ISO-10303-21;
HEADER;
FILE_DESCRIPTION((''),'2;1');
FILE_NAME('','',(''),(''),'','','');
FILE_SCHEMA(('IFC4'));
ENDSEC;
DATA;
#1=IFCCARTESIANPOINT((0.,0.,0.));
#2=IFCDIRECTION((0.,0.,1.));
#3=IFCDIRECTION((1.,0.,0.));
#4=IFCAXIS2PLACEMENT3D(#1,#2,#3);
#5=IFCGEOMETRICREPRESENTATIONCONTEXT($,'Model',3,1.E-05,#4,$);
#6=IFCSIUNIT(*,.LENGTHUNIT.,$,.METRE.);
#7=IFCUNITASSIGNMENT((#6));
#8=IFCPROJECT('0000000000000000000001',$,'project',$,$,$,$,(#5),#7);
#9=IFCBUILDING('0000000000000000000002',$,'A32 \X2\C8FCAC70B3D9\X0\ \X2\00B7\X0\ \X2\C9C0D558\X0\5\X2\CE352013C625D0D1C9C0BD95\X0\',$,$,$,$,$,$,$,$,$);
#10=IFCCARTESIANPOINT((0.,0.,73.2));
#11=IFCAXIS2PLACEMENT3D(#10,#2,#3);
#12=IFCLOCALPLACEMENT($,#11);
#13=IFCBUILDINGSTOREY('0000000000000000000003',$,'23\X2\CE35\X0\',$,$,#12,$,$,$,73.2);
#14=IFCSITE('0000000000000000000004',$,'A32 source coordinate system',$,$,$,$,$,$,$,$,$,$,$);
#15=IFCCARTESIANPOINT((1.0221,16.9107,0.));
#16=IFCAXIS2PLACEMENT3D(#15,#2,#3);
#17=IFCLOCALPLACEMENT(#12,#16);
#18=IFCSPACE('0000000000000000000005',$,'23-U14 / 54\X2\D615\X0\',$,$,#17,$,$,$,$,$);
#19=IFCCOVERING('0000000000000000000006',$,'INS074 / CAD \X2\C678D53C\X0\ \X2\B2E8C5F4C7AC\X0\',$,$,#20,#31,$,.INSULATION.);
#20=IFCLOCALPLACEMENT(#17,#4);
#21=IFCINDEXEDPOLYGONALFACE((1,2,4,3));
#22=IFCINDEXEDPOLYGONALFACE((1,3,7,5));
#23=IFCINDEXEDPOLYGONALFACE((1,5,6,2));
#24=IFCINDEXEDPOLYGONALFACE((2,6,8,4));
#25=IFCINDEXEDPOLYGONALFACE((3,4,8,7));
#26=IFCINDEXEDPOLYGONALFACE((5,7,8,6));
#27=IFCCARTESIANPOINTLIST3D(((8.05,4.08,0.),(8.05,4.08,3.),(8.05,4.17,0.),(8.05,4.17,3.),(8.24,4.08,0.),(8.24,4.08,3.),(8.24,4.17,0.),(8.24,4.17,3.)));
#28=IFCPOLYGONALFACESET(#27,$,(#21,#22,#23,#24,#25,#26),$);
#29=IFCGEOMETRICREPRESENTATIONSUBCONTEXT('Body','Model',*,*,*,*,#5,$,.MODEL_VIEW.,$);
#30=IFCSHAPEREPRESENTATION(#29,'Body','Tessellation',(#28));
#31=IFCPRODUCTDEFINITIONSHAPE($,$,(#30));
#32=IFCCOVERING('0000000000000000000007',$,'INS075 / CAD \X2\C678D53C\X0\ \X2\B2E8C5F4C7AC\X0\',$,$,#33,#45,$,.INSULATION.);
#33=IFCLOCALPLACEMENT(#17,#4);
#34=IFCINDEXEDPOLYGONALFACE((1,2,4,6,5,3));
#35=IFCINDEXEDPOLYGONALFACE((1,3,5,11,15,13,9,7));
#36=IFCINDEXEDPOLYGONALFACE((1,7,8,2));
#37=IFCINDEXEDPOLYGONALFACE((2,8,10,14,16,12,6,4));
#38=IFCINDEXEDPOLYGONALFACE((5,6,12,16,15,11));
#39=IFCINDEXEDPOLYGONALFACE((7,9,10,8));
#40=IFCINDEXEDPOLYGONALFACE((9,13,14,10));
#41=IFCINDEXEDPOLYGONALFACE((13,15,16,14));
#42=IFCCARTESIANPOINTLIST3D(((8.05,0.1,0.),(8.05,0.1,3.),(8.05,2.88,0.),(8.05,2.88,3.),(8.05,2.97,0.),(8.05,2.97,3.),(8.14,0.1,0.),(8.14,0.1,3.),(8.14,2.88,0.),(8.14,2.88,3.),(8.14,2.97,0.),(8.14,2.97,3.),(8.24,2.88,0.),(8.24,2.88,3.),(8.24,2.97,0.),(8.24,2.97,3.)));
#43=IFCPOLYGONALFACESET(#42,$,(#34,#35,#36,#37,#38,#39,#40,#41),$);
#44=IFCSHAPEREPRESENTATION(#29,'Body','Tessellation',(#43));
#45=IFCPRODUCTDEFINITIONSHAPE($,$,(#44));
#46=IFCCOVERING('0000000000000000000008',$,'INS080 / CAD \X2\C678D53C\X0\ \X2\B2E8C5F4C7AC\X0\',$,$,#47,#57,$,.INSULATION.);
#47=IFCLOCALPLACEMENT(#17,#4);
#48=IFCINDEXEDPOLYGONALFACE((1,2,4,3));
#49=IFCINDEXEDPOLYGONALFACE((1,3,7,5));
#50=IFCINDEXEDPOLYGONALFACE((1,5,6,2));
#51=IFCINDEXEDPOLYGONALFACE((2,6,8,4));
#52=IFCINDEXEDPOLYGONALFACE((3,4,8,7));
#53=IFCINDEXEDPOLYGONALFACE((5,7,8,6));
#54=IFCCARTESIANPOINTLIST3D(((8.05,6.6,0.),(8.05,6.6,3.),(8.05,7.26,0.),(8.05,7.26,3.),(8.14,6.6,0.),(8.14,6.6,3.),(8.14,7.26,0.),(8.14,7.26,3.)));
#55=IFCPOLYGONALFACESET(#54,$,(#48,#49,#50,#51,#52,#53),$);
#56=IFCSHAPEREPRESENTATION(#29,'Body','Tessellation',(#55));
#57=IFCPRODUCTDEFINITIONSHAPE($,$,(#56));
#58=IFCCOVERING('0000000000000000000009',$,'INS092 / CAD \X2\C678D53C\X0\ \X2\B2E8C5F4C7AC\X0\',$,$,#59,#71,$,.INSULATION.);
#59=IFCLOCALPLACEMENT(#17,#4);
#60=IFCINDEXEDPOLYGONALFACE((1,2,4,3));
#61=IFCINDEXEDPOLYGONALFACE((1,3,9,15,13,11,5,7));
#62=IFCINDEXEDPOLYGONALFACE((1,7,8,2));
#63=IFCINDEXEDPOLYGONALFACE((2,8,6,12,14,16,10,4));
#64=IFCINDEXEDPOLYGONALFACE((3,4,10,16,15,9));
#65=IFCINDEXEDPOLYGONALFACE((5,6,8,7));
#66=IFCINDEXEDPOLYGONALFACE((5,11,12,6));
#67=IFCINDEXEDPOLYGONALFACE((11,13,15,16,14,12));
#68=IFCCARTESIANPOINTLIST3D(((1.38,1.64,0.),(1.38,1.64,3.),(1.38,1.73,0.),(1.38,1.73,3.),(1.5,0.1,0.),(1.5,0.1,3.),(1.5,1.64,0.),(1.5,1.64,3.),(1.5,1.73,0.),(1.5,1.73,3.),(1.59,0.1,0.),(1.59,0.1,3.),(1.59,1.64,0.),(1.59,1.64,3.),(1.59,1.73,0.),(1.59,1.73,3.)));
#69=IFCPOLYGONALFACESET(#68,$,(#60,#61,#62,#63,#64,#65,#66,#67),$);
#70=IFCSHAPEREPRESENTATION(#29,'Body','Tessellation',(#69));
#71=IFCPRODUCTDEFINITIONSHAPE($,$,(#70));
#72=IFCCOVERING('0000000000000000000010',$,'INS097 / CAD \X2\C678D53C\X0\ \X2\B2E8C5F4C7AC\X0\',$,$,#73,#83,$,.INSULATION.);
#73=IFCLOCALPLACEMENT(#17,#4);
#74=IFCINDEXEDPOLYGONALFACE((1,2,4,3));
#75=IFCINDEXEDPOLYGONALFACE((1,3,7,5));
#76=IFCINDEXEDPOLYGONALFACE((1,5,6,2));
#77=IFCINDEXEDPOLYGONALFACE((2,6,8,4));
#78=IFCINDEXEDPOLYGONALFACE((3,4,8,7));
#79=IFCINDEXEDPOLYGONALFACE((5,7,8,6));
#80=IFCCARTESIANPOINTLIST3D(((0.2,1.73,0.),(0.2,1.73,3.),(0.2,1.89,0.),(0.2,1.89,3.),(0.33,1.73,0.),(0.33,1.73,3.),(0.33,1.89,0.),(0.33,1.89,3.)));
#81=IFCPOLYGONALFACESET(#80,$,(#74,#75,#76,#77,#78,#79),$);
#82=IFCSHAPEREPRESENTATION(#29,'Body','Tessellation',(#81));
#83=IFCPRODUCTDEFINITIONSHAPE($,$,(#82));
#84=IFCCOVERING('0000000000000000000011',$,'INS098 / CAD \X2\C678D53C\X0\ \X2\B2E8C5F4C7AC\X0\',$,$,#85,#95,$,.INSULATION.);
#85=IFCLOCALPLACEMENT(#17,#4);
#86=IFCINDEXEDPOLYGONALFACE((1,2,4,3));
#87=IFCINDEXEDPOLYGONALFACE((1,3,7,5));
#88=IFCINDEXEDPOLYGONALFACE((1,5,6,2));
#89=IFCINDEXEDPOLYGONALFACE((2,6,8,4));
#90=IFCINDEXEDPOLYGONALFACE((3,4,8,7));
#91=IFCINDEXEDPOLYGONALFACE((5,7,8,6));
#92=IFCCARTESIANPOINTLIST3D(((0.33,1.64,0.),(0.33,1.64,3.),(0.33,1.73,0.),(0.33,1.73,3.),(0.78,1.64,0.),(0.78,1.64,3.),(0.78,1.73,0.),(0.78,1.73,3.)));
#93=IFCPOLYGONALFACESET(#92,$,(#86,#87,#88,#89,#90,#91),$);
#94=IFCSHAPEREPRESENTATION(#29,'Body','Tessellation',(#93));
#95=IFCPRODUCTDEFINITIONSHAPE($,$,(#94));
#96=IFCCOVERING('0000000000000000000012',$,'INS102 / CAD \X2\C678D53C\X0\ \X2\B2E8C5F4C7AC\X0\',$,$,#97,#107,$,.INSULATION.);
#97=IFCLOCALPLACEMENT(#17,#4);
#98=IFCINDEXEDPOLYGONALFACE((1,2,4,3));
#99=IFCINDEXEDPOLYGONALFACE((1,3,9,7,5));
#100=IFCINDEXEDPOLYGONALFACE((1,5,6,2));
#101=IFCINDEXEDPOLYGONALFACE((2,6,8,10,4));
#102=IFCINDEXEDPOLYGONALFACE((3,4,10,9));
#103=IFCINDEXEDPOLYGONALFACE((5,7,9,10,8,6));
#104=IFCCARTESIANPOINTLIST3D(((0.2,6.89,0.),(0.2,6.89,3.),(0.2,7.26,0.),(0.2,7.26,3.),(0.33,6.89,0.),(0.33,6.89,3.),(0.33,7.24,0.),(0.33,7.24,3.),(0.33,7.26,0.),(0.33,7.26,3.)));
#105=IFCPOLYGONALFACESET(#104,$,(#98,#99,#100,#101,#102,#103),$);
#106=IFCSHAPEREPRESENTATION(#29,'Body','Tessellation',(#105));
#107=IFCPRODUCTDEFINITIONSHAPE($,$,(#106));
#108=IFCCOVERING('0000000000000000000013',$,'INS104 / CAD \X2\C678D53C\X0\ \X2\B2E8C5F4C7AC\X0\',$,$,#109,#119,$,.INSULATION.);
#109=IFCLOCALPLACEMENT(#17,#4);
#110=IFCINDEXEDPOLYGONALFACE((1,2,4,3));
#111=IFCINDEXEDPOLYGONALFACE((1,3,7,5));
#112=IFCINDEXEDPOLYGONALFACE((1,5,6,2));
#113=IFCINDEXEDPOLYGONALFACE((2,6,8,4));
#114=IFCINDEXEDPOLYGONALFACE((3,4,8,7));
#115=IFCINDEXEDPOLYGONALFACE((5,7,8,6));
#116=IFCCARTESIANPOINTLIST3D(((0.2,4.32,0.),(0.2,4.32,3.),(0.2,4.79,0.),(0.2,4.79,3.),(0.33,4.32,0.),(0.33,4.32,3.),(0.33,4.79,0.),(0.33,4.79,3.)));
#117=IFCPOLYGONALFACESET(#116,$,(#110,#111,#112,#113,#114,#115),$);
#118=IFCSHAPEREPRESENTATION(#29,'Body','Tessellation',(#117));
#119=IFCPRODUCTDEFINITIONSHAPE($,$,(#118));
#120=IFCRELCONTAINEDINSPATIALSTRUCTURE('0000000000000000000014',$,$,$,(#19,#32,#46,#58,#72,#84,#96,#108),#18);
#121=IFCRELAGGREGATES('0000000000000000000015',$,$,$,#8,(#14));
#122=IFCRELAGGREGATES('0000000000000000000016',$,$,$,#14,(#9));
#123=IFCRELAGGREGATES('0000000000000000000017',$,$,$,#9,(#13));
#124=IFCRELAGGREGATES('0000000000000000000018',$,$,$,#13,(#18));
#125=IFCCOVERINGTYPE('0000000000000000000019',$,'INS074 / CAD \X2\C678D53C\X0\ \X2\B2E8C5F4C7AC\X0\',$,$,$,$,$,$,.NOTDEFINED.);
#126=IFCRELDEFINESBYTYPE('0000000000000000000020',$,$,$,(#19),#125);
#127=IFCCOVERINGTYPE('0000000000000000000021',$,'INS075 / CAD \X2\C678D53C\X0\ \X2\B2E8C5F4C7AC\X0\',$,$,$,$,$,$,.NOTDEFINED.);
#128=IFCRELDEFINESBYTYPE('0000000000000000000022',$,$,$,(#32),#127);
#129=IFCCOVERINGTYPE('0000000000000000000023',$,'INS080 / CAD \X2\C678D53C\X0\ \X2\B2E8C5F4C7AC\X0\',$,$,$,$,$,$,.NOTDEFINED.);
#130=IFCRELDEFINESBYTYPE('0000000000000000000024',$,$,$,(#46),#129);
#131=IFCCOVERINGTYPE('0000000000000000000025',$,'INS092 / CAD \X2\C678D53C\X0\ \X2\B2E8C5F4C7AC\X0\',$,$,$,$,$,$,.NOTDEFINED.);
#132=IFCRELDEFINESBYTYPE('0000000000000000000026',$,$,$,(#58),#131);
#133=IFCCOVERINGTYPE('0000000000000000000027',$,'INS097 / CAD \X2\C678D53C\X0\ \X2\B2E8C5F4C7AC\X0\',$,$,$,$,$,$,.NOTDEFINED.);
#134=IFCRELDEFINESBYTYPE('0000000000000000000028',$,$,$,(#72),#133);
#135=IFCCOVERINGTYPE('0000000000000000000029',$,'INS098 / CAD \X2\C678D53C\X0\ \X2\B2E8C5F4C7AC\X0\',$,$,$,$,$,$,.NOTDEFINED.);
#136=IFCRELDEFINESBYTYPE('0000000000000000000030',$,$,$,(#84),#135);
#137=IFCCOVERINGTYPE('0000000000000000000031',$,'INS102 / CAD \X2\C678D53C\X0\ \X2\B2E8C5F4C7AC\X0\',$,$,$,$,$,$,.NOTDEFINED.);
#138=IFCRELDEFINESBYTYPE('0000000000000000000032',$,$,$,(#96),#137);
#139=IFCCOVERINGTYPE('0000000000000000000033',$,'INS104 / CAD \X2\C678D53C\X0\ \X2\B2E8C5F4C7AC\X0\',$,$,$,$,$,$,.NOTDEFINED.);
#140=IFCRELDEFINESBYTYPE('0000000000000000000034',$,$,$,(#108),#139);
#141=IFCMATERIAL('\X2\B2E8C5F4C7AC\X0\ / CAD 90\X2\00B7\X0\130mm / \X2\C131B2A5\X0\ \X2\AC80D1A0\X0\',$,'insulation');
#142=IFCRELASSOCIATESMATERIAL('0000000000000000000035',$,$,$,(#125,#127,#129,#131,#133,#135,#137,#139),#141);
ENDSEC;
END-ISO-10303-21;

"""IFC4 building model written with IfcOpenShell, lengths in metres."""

from ifc_helpers import new_model, si_unit, frame, origin, origin_with_axes, place, context, subcontext, project, spatial, polyline, outline, extrude, source, transform, mapped, material, type_object, type_shapes, element, save


model = new_model("IFC4")

# Units and contexts
model_context = context("Model", 3, precision=1e-05, world=origin_with_axes())
body_context = subcontext(model_context, "Body", "Model", "MODEL_VIEW")
ifc_project = project(units=[si_unit("LENGTHUNIT", "METRE")], contexts=[model_context])

# Site, building, storey, space
storey_placement = place(None, frame((0.0, 0.0, 73.2), z_axis=(0.0, 0.0, 1.0), x_axis=(1.0, 0.0, 0.0)))
space_placement = place(storey_placement, frame((1.0221, 16.9107, 0.0), z_axis=(0.0, 0.0, 1.0), x_axis=(1.0, 0.0, 0.0)))
site = spatial("IfcSite", under=ifc_project, Name="A32 source coordinate system")
building = spatial("IfcBuilding", under=site, Name="A32 주거동 · 지하5층–옥탑지붕")
storey = spatial("IfcBuildingStorey", under=building, at=storey_placement, Name="23층", Elevation=73.2)
space = spatial("IfcSpace", under=storey, at=space_placement, Name="23-U14 / 54형")

# Coverings
ifc_material = material(Name="단열재 / CAD 90·130mm / 성능 검토", Category="insulation")
covering_type_1 = type_object("IfcCoveringType", Name="INS074 / CAD 외피 단열재", PredefinedType="NOTDEFINED", material=ifc_material)
shared_shape_1 = source(origin(), body_context, "Body", "SweptSolid", [
    extrude(outline(polyline([(8.05, 4.08), (8.05, 4.17), (8.24, 4.17), (8.24, 4.08), (8.05, 4.08)])), origin(), (0.0, 0.0, 1.0), 3.0),
])
type_shapes(covering_type_1, [shared_shape_1])
covering_1_placement = place(space_placement, origin_with_axes())
element("IfcCovering", 1, at=covering_1_placement, inside=space, type_object=covering_type_1, Name="INS074 / CAD 외피 단열재", PredefinedType="INSULATION", context=body_context, shape_type="MappedRepresentation", body=[
    mapped(shared_shape_1, transform((0.0, 0.0, 0.0), scale=1.0)),
])
covering_type_2 = type_object("IfcCoveringType", Name="INS075 / CAD 외피 단열재", PredefinedType="NOTDEFINED", material=ifc_material)
shared_shape_2 = source(origin(), body_context, "Body", "SweptSolid", [
    extrude(outline(polyline([(8.24, 2.88), (8.14, 2.88), (8.14, 0.1), (8.05, 0.1), (8.05, 2.88), (8.05, 2.97), (8.14, 2.97), (8.24, 2.97), (8.24, 2.88)])), origin(), (0.0, 0.0, 1.0), 3.0),
])
type_shapes(covering_type_2, [shared_shape_2])
covering_2_placement = place(space_placement, origin_with_axes())
element("IfcCovering", 2, at=covering_2_placement, inside=space, type_object=covering_type_2, Name="INS075 / CAD 외피 단열재", PredefinedType="INSULATION", context=body_context, shape_type="MappedRepresentation", body=[
    mapped(shared_shape_2, transform((0.0, 0.0, 0.0), scale=1.0)),
])
covering_type_3 = type_object("IfcCoveringType", Name="INS080 / CAD 외피 단열재", PredefinedType="NOTDEFINED", material=ifc_material)
shared_shape_3 = source(origin(), body_context, "Body", "SweptSolid", [
    extrude(outline(polyline([(8.14, 7.26), (8.14, 6.6), (8.05, 6.6), (8.05, 7.26), (8.14, 7.26)])), origin(), (0.0, 0.0, 1.0), 3.0),
])
type_shapes(covering_type_3, [shared_shape_3])
covering_3_placement = place(space_placement, origin_with_axes())
element("IfcCovering", 3, at=covering_3_placement, inside=space, type_object=covering_type_3, Name="INS080 / CAD 외피 단열재", PredefinedType="INSULATION", context=body_context, shape_type="MappedRepresentation", body=[
    mapped(shared_shape_3, transform((0.0, 0.0, 0.0), scale=1.0)),
])
covering_type_4 = type_object("IfcCoveringType", Name="INS092 / CAD 외피 단열재", PredefinedType="NOTDEFINED", material=ifc_material)
shared_shape_4 = source(origin(), body_context, "Body", "SweptSolid", [
    extrude(outline(polyline([(1.59, 1.73), (1.59, 1.64), (1.59, 0.1), (1.5, 0.1), (1.5, 1.64), (1.38, 1.64), (1.38, 1.73), (1.5, 1.73), (1.59, 1.73)])), origin(), (0.0, 0.0, 1.0), 3.0),
])
type_shapes(covering_type_4, [shared_shape_4])
covering_4_placement = place(space_placement, origin_with_axes())
element("IfcCovering", 4, at=covering_4_placement, inside=space, type_object=covering_type_4, Name="INS092 / CAD 외피 단열재", PredefinedType="INSULATION", context=body_context, shape_type="MappedRepresentation", body=[
    mapped(shared_shape_4, transform((0.0, 0.0, 0.0), scale=1.0)),
])
covering_type_5 = type_object("IfcCoveringType", Name="INS097 / CAD 외피 단열재", PredefinedType="NOTDEFINED", material=ifc_material)
shared_shape_5 = source(origin(), body_context, "Body", "SweptSolid", [
    extrude(outline(polyline([(0.33, 1.89), (0.33, 1.73), (0.2, 1.73), (0.2, 1.89), (0.33, 1.89)])), origin(), (0.0, 0.0, 1.0), 3.0),
])
type_shapes(covering_type_5, [shared_shape_5])
covering_5_placement = place(space_placement, origin_with_axes())
element("IfcCovering", 5, at=covering_5_placement, inside=space, type_object=covering_type_5, Name="INS097 / CAD 외피 단열재", PredefinedType="INSULATION", context=body_context, shape_type="MappedRepresentation", body=[
    mapped(shared_shape_5, transform((0.0, 0.0, 0.0), scale=1.0)),
])
covering_type_6 = type_object("IfcCoveringType", Name="INS098 / CAD 외피 단열재", PredefinedType="NOTDEFINED", material=ifc_material)
shared_shape_6 = source(origin(), body_context, "Body", "SweptSolid", [
    extrude(outline(polyline([(0.78, 1.73), (0.78, 1.64), (0.33, 1.64), (0.33, 1.73), (0.78, 1.73)])), origin(), (0.0, 0.0, 1.0), 3.0),
])
type_shapes(covering_type_6, [shared_shape_6])
covering_6_placement = place(space_placement, origin_with_axes())
element("IfcCovering", 6, at=covering_6_placement, inside=space, type_object=covering_type_6, Name="INS098 / CAD 외피 단열재", PredefinedType="INSULATION", context=body_context, shape_type="MappedRepresentation", body=[
    mapped(shared_shape_6, transform((0.0, 0.0, 0.0), scale=1.0)),
])
covering_type_7 = type_object("IfcCoveringType", Name="INS102 / CAD 외피 단열재", PredefinedType="NOTDEFINED", material=ifc_material)
shared_shape_7 = source(origin(), body_context, "Body", "SweptSolid", [
    extrude(outline(polyline([(0.33, 7.26), (0.33, 7.24), (0.33, 6.89), (0.2, 6.89), (0.2, 7.26), (0.33, 7.26)])), origin(), (0.0, 0.0, 1.0), 3.0),
])
type_shapes(covering_type_7, [shared_shape_7])
covering_7_placement = place(space_placement, origin_with_axes())
element("IfcCovering", 7, at=covering_7_placement, inside=space, type_object=covering_type_7, Name="INS102 / CAD 외피 단열재", PredefinedType="INSULATION", context=body_context, shape_type="MappedRepresentation", body=[
    mapped(shared_shape_7, transform((0.0, 0.0, 0.0), scale=1.0)),
])
covering_type_8 = type_object("IfcCoveringType", Name="INS104 / CAD 외피 단열재", PredefinedType="NOTDEFINED", material=ifc_material)
shared_shape_8 = source(origin(), body_context, "Body", "SweptSolid", [
    extrude(outline(polyline([(0.33, 4.32), (0.2, 4.32), (0.2, 4.79), (0.33, 4.79), (0.33, 4.32)])), origin(), (0.0, 0.0, 1.0), 3.0),
])
type_shapes(covering_type_8, [shared_shape_8])
covering_8_placement = place(space_placement, origin_with_axes())
element("IfcCovering", 8, at=covering_8_placement, inside=space, type_object=covering_type_8, Name="INS104 / CAD 외피 단열재", PredefinedType="INSULATION", context=body_context, shape_type="MappedRepresentation", body=[
    mapped(shared_shape_8, transform((0.0, 0.0, 0.0), scale=1.0)),
])

save(model, "model.ifc")
